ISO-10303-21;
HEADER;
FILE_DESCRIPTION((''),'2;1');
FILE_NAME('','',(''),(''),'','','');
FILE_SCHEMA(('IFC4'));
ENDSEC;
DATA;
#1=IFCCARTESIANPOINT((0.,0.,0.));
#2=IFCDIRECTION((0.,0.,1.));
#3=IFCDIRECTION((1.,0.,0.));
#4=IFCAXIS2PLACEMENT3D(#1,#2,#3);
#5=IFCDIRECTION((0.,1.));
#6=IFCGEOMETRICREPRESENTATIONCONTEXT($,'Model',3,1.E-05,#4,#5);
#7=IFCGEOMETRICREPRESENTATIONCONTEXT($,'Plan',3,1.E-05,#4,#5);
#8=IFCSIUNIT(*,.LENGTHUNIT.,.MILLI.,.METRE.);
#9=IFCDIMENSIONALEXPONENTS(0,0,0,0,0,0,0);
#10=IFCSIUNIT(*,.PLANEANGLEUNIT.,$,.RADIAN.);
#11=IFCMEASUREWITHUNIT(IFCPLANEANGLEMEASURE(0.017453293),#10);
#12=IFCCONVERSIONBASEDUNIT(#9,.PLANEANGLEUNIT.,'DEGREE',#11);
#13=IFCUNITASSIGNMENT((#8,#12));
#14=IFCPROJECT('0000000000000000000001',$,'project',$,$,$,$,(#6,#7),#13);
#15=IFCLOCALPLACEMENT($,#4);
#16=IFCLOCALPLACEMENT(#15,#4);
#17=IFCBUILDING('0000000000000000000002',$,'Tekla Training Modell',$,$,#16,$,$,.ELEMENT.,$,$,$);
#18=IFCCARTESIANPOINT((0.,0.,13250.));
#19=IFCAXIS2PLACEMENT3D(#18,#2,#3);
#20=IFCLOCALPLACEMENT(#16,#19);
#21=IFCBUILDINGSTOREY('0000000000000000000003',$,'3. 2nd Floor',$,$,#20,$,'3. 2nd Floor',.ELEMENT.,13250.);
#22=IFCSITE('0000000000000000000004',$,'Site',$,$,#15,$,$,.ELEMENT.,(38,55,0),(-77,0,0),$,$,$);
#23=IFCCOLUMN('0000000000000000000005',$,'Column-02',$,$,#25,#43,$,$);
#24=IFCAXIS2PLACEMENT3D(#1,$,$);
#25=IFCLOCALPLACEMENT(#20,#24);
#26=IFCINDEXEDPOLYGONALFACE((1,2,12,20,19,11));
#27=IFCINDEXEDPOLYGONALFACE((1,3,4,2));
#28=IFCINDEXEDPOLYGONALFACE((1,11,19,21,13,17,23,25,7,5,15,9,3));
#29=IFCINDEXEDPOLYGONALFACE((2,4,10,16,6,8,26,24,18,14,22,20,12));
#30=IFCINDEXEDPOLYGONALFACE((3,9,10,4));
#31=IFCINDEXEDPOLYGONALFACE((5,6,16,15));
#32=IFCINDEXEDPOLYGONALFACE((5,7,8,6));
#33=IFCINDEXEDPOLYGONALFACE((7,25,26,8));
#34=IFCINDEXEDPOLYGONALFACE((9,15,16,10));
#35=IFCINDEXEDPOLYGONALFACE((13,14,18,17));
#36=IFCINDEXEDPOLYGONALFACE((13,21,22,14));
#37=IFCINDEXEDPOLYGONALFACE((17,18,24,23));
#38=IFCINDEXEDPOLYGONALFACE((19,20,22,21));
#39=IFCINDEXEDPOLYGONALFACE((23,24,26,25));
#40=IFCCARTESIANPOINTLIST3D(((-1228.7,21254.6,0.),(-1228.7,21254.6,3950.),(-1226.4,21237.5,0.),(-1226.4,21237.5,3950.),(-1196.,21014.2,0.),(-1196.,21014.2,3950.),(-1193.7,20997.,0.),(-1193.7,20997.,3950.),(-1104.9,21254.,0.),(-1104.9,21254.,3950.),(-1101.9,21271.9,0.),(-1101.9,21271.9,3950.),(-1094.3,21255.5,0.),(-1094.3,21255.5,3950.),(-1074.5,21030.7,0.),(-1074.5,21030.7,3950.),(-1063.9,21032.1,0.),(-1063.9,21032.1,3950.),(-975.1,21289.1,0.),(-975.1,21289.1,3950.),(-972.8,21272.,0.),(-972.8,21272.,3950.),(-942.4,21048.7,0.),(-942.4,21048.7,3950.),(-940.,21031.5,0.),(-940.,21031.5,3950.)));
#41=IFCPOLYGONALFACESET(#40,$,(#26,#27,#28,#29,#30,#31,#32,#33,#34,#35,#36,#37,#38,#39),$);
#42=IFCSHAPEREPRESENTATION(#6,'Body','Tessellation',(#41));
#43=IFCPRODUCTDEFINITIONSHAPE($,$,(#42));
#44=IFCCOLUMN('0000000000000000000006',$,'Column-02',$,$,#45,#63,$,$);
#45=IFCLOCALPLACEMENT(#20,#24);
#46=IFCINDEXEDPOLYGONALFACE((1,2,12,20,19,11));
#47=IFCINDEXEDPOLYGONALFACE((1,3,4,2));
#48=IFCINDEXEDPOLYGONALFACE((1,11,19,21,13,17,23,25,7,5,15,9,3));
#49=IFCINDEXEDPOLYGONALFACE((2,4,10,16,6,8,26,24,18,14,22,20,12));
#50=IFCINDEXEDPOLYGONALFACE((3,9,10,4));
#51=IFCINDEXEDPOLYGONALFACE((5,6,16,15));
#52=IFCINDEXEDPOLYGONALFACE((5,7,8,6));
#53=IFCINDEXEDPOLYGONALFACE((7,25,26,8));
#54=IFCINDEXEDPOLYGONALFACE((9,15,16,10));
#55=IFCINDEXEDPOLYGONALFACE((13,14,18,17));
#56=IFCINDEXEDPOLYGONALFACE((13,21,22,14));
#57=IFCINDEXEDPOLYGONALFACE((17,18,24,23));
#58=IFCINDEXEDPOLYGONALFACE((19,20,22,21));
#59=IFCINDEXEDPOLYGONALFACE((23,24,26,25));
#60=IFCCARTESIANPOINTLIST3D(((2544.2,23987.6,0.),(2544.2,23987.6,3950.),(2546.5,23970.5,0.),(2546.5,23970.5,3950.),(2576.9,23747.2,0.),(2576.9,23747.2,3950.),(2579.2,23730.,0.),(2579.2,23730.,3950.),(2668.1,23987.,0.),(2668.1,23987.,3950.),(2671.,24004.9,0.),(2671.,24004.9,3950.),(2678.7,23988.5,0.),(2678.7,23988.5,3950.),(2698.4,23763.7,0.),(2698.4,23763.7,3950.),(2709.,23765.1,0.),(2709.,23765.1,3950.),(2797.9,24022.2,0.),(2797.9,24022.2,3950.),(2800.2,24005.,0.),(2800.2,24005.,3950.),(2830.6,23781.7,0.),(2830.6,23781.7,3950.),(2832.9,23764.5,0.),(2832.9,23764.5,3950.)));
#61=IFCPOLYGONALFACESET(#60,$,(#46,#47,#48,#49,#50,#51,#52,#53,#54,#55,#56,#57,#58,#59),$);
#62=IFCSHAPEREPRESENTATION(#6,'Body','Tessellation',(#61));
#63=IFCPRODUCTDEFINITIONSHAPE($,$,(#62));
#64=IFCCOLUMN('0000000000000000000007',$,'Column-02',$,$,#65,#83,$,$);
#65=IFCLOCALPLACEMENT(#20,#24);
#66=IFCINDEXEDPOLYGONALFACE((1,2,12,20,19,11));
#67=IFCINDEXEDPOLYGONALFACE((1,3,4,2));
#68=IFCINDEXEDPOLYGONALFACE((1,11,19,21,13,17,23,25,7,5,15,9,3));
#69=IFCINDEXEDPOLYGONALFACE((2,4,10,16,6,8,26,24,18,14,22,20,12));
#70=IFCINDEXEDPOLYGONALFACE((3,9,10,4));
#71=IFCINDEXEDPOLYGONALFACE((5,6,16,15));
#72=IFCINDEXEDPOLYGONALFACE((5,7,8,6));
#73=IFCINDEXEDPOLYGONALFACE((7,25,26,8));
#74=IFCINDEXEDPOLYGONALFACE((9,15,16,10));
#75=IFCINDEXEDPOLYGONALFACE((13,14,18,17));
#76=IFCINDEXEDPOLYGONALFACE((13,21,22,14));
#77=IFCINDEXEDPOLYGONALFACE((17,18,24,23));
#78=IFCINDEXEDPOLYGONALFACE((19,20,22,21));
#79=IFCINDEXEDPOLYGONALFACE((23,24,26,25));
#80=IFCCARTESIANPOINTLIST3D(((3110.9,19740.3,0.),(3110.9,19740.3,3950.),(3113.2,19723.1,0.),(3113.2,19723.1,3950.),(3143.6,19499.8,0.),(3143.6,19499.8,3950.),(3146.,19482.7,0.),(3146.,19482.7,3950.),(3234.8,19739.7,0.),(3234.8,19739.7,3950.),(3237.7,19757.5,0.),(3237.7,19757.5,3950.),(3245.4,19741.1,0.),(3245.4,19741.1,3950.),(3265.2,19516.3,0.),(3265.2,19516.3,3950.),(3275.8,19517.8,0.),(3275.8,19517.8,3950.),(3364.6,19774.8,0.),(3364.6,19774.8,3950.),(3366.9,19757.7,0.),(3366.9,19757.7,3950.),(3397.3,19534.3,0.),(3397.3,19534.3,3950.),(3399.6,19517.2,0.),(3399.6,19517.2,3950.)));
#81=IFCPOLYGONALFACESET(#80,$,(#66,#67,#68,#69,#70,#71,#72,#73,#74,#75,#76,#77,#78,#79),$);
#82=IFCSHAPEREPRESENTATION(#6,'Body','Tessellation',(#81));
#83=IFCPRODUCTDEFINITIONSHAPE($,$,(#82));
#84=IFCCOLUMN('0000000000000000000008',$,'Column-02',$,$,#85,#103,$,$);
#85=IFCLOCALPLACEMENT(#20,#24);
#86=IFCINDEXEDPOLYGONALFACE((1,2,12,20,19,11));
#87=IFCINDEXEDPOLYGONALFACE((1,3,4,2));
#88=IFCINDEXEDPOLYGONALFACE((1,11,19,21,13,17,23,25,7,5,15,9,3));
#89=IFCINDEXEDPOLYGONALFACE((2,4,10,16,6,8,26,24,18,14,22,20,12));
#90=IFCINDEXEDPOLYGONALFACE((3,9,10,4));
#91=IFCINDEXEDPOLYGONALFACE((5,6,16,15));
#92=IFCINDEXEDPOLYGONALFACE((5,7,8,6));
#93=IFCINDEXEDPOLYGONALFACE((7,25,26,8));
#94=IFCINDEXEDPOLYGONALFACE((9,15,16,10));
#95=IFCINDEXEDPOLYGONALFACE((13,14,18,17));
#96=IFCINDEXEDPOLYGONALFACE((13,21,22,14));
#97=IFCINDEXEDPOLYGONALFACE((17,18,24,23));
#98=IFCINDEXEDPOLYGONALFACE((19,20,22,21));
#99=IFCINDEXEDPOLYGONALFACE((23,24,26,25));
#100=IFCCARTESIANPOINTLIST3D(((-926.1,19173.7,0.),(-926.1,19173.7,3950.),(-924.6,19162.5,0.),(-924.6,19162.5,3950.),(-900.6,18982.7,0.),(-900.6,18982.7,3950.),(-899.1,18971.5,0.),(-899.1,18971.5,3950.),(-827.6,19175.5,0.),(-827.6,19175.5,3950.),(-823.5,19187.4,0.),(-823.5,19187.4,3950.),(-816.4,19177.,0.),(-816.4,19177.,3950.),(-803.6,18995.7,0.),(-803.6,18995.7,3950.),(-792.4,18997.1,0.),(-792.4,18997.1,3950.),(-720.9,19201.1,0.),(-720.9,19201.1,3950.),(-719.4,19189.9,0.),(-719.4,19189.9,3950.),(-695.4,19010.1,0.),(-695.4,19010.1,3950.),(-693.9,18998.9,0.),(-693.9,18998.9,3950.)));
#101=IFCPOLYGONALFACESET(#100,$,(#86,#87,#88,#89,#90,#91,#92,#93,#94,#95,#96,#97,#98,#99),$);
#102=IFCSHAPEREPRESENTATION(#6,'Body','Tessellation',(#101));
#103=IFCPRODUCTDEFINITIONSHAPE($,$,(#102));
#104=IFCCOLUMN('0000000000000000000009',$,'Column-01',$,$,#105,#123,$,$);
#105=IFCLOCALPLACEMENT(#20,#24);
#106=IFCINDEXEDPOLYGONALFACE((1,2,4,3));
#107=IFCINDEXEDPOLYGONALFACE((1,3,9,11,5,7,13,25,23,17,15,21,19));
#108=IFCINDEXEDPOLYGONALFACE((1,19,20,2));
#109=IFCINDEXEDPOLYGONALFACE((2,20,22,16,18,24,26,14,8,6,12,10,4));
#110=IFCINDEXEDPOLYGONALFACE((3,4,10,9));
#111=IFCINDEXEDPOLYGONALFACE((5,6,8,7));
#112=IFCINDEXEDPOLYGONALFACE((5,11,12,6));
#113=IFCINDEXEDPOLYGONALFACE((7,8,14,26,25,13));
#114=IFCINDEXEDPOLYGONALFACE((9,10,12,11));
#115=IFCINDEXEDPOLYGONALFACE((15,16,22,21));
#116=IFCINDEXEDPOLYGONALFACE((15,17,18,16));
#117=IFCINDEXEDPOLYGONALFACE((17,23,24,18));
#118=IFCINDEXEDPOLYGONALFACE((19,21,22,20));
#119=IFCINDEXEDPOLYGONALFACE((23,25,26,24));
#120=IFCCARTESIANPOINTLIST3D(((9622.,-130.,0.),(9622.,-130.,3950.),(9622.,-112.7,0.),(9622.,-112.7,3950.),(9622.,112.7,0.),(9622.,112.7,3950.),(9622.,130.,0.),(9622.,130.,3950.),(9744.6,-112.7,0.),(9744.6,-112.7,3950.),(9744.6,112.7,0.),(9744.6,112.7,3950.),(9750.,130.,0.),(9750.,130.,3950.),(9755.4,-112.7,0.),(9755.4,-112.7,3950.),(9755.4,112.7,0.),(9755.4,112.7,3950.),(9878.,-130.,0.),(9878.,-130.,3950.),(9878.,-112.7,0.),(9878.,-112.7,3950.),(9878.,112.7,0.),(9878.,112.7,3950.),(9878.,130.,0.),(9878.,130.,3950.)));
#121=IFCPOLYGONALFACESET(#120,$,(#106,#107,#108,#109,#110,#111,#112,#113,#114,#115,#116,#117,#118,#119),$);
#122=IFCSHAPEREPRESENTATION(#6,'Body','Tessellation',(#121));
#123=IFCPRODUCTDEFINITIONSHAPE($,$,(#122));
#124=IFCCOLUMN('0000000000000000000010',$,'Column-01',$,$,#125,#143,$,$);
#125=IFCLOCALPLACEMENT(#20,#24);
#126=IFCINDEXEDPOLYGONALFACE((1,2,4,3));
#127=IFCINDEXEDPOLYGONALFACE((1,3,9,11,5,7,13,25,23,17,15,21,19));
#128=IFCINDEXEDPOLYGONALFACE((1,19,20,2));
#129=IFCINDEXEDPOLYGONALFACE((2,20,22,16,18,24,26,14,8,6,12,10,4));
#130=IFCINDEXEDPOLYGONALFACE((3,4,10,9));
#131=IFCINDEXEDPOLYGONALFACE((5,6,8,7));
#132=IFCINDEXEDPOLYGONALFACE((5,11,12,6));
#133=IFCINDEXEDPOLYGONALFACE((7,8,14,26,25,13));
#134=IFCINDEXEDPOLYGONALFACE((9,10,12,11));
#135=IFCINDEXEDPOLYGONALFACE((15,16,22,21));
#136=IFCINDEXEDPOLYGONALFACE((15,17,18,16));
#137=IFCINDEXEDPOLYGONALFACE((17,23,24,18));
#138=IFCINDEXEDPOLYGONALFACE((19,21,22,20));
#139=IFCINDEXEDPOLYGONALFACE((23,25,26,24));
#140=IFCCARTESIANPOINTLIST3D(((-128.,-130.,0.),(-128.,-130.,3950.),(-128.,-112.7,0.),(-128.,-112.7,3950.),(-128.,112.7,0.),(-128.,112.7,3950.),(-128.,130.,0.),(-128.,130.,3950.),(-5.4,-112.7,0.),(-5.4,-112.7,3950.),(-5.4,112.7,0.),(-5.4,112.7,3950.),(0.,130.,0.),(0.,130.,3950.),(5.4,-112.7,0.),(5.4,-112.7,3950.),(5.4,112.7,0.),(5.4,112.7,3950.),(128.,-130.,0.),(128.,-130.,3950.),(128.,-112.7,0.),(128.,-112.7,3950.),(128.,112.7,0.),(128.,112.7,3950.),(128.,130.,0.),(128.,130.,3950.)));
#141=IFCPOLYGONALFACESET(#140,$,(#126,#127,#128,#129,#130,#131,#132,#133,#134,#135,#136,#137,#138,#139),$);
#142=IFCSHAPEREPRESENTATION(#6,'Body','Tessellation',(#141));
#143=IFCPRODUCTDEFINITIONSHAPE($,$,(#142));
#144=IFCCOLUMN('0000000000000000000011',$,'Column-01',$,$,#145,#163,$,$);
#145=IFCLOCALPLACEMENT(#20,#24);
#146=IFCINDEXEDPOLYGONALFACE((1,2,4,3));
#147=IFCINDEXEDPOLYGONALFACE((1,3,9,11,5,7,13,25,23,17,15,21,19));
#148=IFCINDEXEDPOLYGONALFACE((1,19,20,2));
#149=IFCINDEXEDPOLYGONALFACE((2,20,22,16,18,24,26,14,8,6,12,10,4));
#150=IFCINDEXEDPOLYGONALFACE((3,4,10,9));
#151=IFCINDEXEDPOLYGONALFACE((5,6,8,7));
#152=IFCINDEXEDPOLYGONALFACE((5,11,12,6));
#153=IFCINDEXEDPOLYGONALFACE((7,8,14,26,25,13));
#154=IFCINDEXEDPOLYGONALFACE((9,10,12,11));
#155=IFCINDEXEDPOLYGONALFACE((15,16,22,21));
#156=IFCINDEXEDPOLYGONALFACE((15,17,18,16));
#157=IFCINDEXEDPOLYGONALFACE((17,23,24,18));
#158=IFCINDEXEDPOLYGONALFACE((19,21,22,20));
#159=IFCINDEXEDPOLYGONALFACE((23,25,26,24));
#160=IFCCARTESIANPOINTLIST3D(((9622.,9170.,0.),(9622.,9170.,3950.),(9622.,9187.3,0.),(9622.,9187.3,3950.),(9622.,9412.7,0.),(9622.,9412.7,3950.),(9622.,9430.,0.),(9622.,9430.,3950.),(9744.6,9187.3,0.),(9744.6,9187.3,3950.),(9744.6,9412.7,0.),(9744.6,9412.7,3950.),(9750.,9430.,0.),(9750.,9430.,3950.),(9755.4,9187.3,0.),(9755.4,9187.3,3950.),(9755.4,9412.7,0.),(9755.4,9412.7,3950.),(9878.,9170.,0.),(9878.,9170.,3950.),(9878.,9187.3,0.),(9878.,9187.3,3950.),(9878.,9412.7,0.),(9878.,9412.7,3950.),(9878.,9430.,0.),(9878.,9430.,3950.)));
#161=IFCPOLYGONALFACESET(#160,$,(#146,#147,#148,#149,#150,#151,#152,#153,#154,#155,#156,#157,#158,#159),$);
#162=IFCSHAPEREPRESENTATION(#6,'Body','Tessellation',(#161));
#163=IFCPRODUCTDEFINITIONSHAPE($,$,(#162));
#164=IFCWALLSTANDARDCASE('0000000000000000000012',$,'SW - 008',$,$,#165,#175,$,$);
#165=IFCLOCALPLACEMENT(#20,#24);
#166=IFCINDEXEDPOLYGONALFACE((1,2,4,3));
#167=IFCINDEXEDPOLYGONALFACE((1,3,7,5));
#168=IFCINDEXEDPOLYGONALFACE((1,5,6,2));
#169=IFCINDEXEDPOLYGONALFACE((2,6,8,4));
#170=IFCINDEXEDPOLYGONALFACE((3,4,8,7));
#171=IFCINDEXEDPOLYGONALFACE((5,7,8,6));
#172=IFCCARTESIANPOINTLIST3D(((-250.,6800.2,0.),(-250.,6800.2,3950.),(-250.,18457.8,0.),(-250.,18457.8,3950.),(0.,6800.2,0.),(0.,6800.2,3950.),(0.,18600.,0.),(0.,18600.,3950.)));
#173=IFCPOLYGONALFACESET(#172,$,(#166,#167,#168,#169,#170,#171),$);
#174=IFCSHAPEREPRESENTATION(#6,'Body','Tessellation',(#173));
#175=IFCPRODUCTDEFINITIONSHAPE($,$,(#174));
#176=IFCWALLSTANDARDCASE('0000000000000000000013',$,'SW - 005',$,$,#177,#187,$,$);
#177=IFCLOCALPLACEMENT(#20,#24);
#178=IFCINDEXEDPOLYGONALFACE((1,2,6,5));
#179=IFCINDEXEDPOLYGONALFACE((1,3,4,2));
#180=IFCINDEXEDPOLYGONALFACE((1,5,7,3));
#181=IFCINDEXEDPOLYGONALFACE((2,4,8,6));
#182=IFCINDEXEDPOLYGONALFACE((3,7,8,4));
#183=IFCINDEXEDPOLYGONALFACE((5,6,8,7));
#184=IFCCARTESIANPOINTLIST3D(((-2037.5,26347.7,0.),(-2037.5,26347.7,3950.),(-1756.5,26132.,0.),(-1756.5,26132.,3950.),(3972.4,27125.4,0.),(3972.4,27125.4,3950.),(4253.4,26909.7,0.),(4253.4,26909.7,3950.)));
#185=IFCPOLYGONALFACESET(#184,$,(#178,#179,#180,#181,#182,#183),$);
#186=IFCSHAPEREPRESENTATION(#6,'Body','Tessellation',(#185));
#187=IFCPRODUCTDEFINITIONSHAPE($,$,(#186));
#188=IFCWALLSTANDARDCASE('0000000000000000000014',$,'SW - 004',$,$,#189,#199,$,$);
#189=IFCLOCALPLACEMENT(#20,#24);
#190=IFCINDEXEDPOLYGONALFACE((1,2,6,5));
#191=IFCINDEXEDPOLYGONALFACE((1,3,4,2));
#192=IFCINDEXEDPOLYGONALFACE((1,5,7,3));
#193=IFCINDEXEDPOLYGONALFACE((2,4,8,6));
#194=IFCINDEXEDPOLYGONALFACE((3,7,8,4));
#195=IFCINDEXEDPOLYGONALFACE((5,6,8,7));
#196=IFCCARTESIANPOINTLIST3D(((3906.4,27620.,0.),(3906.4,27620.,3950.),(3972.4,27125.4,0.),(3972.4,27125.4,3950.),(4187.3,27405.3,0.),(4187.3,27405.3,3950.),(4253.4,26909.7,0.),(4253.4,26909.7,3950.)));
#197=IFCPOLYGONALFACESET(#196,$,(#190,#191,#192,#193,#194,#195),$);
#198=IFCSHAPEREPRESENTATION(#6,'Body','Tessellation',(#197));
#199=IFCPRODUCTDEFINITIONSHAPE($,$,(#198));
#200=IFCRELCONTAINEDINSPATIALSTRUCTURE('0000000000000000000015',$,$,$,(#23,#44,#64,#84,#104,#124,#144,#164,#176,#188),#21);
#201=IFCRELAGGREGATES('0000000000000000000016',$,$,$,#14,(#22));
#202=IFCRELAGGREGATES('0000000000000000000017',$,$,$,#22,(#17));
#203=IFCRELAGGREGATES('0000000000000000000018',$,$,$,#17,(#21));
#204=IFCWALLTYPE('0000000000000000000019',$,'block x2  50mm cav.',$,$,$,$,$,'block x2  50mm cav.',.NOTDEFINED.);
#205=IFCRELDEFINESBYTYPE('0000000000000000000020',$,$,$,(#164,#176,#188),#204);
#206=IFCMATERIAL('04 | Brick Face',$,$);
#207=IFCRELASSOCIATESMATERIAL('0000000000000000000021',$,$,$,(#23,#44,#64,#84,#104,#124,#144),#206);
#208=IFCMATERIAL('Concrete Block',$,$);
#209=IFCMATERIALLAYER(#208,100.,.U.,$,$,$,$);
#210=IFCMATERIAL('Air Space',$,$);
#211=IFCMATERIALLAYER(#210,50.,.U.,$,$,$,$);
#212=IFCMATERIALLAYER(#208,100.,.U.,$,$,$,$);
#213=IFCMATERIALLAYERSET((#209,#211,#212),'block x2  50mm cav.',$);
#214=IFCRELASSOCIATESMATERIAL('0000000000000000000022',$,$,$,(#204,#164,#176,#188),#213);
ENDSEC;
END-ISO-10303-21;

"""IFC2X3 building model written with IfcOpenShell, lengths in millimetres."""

from ifc_helpers import new_model, entity, si_unit, converted_unit, direction, frame, origin_with_axes, place, context, project, spatial, polyline, outline, extrude, material, layer, layer_set, layer_usage, type_object, element, save


model = new_model("IFC2X3")

# Units and contexts
model_context = context("Model", 3, precision=1e-05, world=origin_with_axes(), true_north=direction((0.0, 1.0)))
plan_context = context("Plan", 3, precision=1e-05, world=origin_with_axes(), true_north=direction((0.0, 1.0)))
ifc_project = project(units=[si_unit("LENGTHUNIT", "METRE", prefix="MILLI"), converted_unit("PLANEANGLEUNIT", "DEGREE", entity("IfcPlaneAngleMeasure", 0.017453293), si_unit("PLANEANGLEUNIT", "RADIAN"), dimensions=[0, 0, 0, 0, 0, 0, 0])], contexts=[model_context, plan_context])

# Site, building, storey
site_placement = place(None, origin_with_axes())
site = spatial("IfcSite", under=ifc_project, at=site_placement, Name="Site", CompositionType="ELEMENT", RefLatitude=(38, 55, 0), RefLongitude=(-77, 0, 0))
building_placement = place(site_placement, origin_with_axes())
building = spatial("IfcBuilding", under=site, at=building_placement, Name="Tekla Training Modell", CompositionType="ELEMENT")
storey_placement = place(building_placement, frame((0.0, 0.0, 13250.0), z_axis=(0.0, 0.0, 1.0), x_axis=(1.0, 0.0, 0.0)))
storey = spatial("IfcBuildingStorey", under=building, at=storey_placement, Name="3. 2nd Floor", LongName="3. 2nd Floor", CompositionType="ELEMENT", Elevation=13250.0)

# Columns
ifc_material_1 = material(Name="04 | Brick Face")
for number, where, z_axis, x_axis, name in (
    (1, (-1084.4, 21143.1, 0.0), (0.0, 0.0, 1.0), (0.990872, 0.134803, 0.0), "Column-02"),
    (2, (2688.5, 23876.1, 0.0), (0.0, 0.0, 1.0), (0.990872, 0.134803, 0.0), "Column-02"),
    (3, (3255.3, 19628.7, 0.0), (0.0, 0.0, 1.0), (0.990872, 0.134803, 0.0), "Column-02"),
):
    element("IfcColumn", number, at=place(storey_placement, frame(where, z_axis=z_axis, x_axis=x_axis)), inside=storey, material=ifc_material_1, Name=name, context=model_context, shape_type="SweptSolid", body=[
        extrude(outline(polyline([(0.0, 130.0), (-128.0, 130.0), (-128.0, 112.7), (-5.3, 112.7), (-5.3, -112.7), (-128.0, -112.7), (-128.0, -130.0), (128.0, -130.0), (128.0, -112.7), (5.3, -112.7), (5.3, 112.7), (128.0, 112.7), (128.0, 130.0), (0.0, 130.0)])), origin_with_axes(), (0.0, 0.0, 1.0), 3950.0),
    ])
column_placement = place(storey_placement, frame((-810.0, 19086.3, 0.0), z_axis=(0.0, 0.0, 1.0), x_axis=(0.991216, 0.132256, 0.0)))
element("IfcColumn", 4, at=column_placement, inside=storey, material=ifc_material_1, Name="Column-02", context=model_context, shape_type="SweptSolid", body=[
    extrude(outline(polyline([(0.0, 102.0), (-103.5, 102.0), (-103.5, 90.7), (-5.7, 90.7), (-5.7, -90.7), (-103.5, -90.7), (-103.5, -102.0), (103.5, -102.0), (103.5, -90.7), (5.7, -90.7), (5.7, 90.7), (103.5, 90.7), (103.5, 102.0), (0.0, 102.0)])), origin_with_axes(), (0.0, 0.0, 1.0), 3950.0),
])
for number, where, z_axis, x_axis, name in (
    (5, (9750.0, 0.0, 0.0), (0.0, 0.0, 1.0), (1.0, 0.0, 0.0), "Column-01"),
    (6, (0.0, 0.0, 0.0), (0.0, 0.0, 1.0), (1.0, 0.0, 0.0), "Column-01"),
    (7, (9750.0, 9300.0, 0.0), (0.0, 0.0, 1.0), (1.0, 0.0, 0.0), "Column-01"),
):
    element("IfcColumn", number, at=place(storey_placement, frame(where, z_axis=z_axis, x_axis=x_axis)), inside=storey, material=ifc_material_1, Name=name, context=model_context, shape_type="SweptSolid", body=[
        extrude(outline(polyline([(0.0, 130.0), (-128.0, 130.0), (-128.0, 112.7), (-5.3, 112.7), (-5.3, -112.7), (-128.0, -112.7), (-128.0, -130.0), (128.0, -130.0), (128.0, -112.7), (5.3, -112.7), (5.3, 112.7), (128.0, 112.7), (128.0, 130.0), (0.0, 130.0)])), origin_with_axes(), (0.0, 0.0, 1.0), 3950.0),
    ])

# Walls
ifc_material_2 = material(Name="Concrete Block")
ifc_layer_1 = layer(ifc_material_2, 100.0, ventilated="UNKNOWN")
ifc_material_3 = material(Name="Air Space")
ifc_layer_2 = layer(ifc_material_3, 50.0, ventilated="UNKNOWN")
ifc_layer_3 = layer(ifc_material_2, 100.0, ventilated="UNKNOWN")
ifc_layer_set_1 = layer_set([ifc_layer_1, ifc_layer_2, ifc_layer_3], Name="block x2  50mm cav.")
ifc_layer_usage_1 = layer_usage(ifc_layer_set_1, "AXIS2", "NEGATIVE", 0.0)
wall_type = type_object("IfcWallType", Name="block x2  50mm cav.", ElementType="block x2  50mm cav.", PredefinedType="NOTDEFINED", material=ifc_layer_set_1)
wall_1_placement = place(storey_placement, frame((0.0, 18600.0, 0.0), z_axis=(0.0, 0.0, 1.0), x_axis=(0.0, -1.0, 0.0)))
element("IfcWallStandardCase", 8, at=wall_1_placement, inside=storey, type_object=wall_type, material=ifc_layer_usage_1, Name="SW - 008", context=model_context, shape_type="SweptSolid", body=[
    extrude(outline(polyline([(142.2, -250.0), (11799.8, -250.0), (11799.8, 0.0), (0.0, 0.0), (142.2, -250.0)])), origin_with_axes(), (0.0, 0.0, 1.0), 3950.0),
])
ifc_layer_usage_2 = layer_usage(ifc_layer_set_1, "AXIS2", "NEGATIVE", 0.0)
wall_2_placement = place(storey_placement, frame((4253.4, 26909.7, 0.0), z_axis=(0.0, 0.0, 1.0), x_axis=(-0.991732, -0.12833, 0.0)))
element("IfcWallStandardCase", 9, at=wall_2_placement, inside=storey, type_object=wall_type, material=ifc_layer_usage_2, Name="SW - 005", context=model_context, shape_type="SweptSolid", body=[
    extrude(outline(polyline([(251.0, -250.0), (6311.0, -250.0), (6060.0, 0.0), (0.0, 0.0), (251.0, -250.0)])), origin_with_axes(), (0.0, 0.0, 1.0), 3950.0),
])
ifc_layer_usage_3 = layer_usage(ifc_layer_set_1, "AXIS2", "NEGATIVE", 0.0)
wall_3_placement = place(storey_placement, frame((4187.3, 27405.3, 0.0), z_axis=(0.0, 0.0, 1.0), x_axis=(0.132257, -0.991215, 0.0)))
element("IfcWallStandardCase", 10, at=wall_3_placement, inside=storey, type_object=wall_type, material=ifc_layer_usage_3, Name="SW - 004", context=model_context, shape_type="SweptSolid", body=[
    extrude(outline(polyline([(-250.0, -250.0), (249.0, -250.0), (500.0, 0.0), (0.0, 0.0), (-250.0, -250.0)])), origin_with_axes(), (0.0, 0.0, 1.0), 3950.0),
])

save(model, "model.ifc")
